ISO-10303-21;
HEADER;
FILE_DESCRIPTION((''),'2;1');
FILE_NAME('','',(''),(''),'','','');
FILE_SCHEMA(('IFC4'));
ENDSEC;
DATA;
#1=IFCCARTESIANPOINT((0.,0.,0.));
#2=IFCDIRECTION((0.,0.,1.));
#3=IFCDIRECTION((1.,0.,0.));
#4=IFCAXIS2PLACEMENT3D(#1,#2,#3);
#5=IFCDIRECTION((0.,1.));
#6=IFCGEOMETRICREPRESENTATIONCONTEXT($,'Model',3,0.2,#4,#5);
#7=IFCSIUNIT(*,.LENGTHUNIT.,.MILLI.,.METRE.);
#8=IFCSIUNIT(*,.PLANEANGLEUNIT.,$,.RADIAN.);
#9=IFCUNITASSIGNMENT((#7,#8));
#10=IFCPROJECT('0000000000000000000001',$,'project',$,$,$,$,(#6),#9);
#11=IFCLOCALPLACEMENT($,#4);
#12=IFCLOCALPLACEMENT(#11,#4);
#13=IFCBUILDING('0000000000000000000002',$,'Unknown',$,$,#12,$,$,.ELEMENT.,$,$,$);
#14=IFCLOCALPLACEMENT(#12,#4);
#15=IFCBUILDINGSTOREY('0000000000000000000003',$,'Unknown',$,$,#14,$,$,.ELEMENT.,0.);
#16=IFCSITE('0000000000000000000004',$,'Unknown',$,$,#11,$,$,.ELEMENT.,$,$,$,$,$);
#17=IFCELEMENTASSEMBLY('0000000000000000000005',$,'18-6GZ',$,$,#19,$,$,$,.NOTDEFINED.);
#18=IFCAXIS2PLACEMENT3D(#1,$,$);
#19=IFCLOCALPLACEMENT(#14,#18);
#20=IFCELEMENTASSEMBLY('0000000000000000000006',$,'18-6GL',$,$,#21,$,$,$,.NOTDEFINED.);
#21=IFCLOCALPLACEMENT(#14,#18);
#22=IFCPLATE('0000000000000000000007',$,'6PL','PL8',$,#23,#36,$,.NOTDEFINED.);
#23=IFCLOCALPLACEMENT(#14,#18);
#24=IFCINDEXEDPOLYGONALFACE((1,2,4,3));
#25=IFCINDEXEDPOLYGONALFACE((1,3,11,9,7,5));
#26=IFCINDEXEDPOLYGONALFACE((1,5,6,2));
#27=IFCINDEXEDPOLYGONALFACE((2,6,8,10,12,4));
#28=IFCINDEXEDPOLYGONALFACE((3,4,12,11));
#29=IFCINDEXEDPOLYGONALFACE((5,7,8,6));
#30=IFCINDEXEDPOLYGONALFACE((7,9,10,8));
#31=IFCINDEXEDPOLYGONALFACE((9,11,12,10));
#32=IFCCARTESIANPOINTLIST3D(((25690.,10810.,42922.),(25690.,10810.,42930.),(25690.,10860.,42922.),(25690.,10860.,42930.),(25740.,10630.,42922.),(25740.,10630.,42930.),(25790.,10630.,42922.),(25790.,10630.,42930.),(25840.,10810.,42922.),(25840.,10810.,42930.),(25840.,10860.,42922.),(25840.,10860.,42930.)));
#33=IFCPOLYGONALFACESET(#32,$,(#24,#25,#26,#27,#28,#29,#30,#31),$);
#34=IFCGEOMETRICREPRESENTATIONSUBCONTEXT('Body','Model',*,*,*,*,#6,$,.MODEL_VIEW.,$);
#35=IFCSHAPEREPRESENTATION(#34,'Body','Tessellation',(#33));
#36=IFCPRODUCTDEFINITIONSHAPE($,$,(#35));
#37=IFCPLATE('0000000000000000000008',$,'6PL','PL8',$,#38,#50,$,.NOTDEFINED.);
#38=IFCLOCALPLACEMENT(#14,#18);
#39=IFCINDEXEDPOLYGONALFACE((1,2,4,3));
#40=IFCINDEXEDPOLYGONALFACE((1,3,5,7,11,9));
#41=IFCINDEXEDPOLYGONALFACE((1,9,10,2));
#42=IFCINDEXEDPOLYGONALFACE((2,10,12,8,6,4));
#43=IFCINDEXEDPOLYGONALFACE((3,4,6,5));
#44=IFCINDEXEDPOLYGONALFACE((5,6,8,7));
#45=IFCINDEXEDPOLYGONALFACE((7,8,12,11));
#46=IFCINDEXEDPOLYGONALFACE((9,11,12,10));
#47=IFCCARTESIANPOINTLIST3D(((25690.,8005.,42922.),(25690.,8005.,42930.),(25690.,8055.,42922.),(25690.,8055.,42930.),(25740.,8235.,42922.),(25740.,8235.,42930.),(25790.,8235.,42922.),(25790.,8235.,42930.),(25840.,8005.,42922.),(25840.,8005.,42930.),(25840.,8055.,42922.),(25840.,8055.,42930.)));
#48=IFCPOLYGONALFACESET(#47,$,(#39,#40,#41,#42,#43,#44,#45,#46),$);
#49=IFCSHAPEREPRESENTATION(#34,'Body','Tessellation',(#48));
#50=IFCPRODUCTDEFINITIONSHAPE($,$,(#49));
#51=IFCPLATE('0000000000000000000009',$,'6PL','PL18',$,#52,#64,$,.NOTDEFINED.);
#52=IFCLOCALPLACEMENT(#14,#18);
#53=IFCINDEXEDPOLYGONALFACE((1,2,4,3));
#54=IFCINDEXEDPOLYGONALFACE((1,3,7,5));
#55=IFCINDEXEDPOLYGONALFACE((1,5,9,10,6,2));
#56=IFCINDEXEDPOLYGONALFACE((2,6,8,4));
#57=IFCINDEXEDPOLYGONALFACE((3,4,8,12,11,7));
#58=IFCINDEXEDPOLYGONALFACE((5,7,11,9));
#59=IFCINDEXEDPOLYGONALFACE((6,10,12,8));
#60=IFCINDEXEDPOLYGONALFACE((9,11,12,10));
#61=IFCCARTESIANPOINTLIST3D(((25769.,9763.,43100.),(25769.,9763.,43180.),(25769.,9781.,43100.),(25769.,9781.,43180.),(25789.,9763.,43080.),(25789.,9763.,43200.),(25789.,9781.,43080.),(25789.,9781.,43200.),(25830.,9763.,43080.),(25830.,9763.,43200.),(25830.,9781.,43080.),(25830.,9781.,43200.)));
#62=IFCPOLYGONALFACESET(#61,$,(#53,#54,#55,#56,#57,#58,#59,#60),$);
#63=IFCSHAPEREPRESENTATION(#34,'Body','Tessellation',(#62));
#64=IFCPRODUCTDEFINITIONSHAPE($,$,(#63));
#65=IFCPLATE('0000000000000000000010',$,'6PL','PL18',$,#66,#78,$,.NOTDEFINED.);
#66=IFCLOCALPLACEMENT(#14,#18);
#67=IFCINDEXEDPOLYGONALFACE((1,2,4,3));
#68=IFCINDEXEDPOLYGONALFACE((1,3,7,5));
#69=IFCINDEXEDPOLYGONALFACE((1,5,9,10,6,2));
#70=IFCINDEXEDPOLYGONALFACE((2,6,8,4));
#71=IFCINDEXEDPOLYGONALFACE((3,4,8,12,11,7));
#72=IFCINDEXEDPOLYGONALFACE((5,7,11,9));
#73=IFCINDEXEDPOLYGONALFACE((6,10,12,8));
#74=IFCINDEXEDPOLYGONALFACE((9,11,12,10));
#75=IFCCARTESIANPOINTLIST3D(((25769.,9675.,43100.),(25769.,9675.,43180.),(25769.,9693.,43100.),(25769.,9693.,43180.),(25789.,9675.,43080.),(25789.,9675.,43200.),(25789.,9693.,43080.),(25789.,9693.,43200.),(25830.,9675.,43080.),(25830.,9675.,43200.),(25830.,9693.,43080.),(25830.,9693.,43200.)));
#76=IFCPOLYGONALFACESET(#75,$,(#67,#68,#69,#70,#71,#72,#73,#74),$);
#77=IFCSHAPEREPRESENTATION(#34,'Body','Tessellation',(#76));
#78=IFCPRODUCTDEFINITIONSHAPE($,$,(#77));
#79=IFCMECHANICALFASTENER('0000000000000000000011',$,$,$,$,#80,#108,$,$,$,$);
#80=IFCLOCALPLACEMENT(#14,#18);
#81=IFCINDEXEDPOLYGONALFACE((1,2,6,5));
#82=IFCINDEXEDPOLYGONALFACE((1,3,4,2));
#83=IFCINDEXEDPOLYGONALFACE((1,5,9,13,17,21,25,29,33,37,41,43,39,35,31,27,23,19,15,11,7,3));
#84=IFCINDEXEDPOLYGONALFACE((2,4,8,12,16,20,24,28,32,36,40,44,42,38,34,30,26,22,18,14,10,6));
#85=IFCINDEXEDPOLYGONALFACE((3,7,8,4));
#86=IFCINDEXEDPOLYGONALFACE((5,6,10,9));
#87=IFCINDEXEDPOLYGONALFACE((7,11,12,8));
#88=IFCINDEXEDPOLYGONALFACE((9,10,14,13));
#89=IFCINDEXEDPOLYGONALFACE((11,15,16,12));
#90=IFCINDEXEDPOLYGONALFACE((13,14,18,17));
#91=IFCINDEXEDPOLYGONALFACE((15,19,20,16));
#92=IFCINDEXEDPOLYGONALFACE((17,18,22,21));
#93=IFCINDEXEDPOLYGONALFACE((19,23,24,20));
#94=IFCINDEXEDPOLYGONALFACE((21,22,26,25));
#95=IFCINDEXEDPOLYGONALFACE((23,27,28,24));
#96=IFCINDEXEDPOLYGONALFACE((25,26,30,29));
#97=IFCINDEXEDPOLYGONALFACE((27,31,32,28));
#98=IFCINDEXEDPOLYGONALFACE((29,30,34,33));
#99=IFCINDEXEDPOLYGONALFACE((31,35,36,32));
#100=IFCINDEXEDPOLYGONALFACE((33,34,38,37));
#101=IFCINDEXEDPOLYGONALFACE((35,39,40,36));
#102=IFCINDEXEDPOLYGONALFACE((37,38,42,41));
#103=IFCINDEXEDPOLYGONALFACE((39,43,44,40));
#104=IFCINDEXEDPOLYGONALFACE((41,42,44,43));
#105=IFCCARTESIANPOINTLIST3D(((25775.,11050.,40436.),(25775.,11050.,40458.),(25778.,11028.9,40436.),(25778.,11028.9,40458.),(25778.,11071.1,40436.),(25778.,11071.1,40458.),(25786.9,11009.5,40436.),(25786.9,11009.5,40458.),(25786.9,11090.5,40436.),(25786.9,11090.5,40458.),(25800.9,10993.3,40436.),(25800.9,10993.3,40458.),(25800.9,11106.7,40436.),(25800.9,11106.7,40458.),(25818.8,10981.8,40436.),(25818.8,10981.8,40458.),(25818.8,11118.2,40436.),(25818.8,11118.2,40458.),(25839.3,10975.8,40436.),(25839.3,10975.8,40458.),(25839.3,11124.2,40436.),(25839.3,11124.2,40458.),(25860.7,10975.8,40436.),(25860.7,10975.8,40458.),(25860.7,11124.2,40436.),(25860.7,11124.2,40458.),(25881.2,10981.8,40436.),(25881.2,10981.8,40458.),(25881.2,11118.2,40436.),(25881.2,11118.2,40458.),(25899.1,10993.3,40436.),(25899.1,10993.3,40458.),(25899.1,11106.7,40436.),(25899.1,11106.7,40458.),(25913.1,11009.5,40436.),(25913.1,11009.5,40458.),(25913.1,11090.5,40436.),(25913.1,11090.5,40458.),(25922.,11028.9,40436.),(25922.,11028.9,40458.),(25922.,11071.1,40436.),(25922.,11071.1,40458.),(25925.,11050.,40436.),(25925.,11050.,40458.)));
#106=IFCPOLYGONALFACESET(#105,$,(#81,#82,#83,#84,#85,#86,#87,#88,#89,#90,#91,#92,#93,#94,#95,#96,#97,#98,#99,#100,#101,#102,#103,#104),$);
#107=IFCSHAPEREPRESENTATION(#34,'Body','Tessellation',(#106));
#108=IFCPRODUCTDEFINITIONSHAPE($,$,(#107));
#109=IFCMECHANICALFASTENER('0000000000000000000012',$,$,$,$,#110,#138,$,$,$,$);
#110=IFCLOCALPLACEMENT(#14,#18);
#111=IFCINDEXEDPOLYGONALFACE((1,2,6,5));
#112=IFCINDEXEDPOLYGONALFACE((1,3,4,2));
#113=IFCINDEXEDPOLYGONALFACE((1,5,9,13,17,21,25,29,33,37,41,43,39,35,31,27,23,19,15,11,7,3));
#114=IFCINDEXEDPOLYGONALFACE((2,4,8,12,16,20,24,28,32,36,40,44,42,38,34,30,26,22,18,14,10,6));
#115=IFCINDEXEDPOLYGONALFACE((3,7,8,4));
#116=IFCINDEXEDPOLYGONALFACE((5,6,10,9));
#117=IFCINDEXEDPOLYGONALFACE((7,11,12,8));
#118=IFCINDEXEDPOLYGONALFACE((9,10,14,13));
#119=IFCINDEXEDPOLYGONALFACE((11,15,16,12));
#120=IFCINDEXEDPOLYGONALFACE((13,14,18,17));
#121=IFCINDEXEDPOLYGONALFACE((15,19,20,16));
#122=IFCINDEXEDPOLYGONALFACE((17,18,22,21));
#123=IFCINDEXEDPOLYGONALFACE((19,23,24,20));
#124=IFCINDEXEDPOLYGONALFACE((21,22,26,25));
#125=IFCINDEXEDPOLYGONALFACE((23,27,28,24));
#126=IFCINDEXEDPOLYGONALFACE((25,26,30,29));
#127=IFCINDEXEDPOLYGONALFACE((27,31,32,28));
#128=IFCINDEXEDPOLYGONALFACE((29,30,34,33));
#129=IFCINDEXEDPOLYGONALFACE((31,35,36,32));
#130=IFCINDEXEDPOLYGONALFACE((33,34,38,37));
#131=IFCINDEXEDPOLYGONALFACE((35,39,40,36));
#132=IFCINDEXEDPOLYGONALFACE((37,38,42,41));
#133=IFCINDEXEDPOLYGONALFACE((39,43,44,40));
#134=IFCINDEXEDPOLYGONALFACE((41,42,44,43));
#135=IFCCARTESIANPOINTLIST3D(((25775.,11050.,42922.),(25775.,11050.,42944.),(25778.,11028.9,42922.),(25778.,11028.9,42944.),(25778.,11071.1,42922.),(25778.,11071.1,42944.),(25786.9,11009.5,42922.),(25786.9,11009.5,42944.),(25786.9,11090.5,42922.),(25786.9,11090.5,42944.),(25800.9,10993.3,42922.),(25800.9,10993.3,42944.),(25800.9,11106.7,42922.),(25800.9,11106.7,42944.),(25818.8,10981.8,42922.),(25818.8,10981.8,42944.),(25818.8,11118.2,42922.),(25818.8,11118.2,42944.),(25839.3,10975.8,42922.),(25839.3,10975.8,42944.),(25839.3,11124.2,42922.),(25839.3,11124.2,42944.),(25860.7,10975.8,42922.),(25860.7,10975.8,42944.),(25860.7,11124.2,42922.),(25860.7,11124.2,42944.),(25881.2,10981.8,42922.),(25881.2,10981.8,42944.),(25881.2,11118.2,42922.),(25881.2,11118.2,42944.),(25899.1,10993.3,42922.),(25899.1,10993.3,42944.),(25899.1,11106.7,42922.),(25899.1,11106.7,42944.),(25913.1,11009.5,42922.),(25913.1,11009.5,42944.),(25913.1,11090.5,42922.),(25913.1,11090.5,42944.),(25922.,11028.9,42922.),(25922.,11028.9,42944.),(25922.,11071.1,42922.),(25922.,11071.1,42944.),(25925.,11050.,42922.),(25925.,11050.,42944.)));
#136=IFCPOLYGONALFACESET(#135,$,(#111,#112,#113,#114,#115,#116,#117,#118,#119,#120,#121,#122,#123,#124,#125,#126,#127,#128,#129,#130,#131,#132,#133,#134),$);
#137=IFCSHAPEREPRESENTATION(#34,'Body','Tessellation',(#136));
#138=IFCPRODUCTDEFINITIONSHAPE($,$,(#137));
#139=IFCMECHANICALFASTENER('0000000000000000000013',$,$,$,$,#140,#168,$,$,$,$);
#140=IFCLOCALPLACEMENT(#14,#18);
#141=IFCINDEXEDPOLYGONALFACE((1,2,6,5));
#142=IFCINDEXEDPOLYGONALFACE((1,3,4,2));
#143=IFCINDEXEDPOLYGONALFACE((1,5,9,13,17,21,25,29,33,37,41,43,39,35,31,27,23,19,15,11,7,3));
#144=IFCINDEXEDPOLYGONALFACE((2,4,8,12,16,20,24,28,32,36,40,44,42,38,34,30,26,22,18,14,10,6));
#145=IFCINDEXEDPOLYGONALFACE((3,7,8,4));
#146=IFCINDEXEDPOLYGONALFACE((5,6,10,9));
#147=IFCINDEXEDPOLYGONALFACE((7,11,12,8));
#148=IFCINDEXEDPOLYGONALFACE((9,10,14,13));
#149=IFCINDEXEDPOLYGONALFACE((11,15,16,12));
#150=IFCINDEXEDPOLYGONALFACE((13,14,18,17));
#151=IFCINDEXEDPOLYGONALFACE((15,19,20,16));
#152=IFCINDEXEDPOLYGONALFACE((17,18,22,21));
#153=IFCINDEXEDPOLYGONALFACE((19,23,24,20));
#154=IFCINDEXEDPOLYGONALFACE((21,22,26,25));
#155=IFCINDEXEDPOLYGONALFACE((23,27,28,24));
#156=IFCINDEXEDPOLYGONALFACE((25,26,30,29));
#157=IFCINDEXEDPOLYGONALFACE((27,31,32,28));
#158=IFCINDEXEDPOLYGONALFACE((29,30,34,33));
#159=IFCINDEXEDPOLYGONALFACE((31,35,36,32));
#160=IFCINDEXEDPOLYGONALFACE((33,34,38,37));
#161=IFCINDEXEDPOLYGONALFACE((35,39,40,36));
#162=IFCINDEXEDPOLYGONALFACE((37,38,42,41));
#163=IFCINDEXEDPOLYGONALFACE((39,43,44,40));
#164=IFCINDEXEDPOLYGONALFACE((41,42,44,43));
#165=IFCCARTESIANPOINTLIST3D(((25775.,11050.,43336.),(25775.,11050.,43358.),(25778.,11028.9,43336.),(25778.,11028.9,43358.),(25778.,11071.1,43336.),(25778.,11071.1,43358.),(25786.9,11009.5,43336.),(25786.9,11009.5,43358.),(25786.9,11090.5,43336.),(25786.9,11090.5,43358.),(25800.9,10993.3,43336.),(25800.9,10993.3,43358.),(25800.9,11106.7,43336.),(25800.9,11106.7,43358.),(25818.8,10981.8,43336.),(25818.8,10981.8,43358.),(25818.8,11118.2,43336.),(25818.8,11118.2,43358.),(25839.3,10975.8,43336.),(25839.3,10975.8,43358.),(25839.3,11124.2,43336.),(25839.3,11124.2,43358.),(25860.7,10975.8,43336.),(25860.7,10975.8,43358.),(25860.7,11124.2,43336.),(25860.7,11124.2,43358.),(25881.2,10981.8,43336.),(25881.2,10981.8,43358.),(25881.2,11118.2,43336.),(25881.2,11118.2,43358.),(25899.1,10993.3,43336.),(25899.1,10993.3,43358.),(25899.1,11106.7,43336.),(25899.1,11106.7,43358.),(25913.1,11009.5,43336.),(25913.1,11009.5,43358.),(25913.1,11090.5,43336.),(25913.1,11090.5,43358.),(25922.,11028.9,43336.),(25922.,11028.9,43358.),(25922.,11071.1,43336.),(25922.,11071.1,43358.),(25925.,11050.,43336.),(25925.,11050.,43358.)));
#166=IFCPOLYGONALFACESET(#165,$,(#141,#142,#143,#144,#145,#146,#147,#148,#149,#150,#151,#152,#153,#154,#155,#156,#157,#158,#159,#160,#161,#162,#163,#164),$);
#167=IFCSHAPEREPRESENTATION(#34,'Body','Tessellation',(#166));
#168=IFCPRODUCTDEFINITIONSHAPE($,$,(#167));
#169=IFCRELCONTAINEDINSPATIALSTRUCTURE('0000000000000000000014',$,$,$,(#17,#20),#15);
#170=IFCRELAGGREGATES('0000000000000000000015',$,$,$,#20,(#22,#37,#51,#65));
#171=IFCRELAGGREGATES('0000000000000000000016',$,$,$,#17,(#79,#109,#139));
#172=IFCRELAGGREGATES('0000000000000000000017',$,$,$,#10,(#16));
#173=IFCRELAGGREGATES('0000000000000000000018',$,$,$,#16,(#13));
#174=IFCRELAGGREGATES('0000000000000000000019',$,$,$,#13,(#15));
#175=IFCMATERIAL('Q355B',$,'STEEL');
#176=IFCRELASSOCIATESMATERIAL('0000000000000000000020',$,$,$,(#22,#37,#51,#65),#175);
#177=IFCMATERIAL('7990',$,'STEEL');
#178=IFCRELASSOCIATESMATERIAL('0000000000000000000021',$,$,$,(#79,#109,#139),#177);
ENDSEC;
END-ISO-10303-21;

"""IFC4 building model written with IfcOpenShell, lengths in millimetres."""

from ifc_helpers import new_model, si_unit, direction, frame, origin_with_axes, place, context, subcontext, project, spatial, line, arc, indexed_curve, outline, extrude, source, transform, mapped, material, element, aggregate, save


model = new_model("IFC4")

# Units and contexts
model_context = context("Model", 3, precision=0.2, world=origin_with_axes(), true_north=direction((0.0, 1.0)))
body_context = subcontext(model_context, "Body", "Model", "MODEL_VIEW")
ifc_project = project(units=[si_unit("LENGTHUNIT", "METRE", prefix="MILLI"), si_unit("PLANEANGLEUNIT", "RADIAN")], contexts=[model_context])

# Site, building, storey
site_placement = place(None, origin_with_axes())
site = spatial("IfcSite", under=ifc_project, at=site_placement, Name="Unknown", CompositionType="ELEMENT")
building_placement = place(site_placement, origin_with_axes())
building = spatial("IfcBuilding", under=site, at=building_placement, Name="Unknown", CompositionType="ELEMENT")
storey_placement = place(building_placement, origin_with_axes())
storey = spatial("IfcBuildingStorey", under=building, at=storey_placement, Name="Unknown", CompositionType="ELEMENT", Elevation=0.0)

# Element assembly
assembly_1_placement = place(storey_placement, frame((25850.0, 11050.0, 35950.0), z_axis=(-1.0, 0.0, 0.0), x_axis=(0.0, 0.0, 1.0)))
assembly_1 = element("IfcElementAssembly", 1, at=assembly_1_placement, inside=storey, Name="18-6GZ", PredefinedType="NOTDEFINED")
ifc_material_1 = material(Name="Q355B", Category="STEEL")

# Element assembly
assembly_2_placement = place(storey_placement, frame((25765.0, 10900.0, 43140.0), z_axis=(-1.0, 0.0, 0.0), x_axis=(0.0, -1.0, 0.0)))
assembly_2 = element("IfcElementAssembly", 2, at=assembly_2_placement, inside=storey, Name="18-6GL", PredefinedType="NOTDEFINED")

# Plates
plate_1_placement = place(assembly_2_placement, frame((90.0, -214.0, -75.0), z_axis=(0.0, 1.0, 0.0), x_axis=(-1.0, 0.0, 0.0)))
plate_1 = element("IfcPlate", 3, at=plate_1_placement, material=ifc_material_1, Name="6PL", Description="PL8", PredefinedType="NOTDEFINED", context=body_context, shape_type="SolidModel", body=[
    extrude(outline(indexed_curve([(0.0, 0.0), (50.0, 0.0), (50.0, 150.0), (0.0, 150.0), (-180.0, 100.0), (-180.0, 50.0)], segments=[line(1, 2, 3, 4, 5, 6, 1)])), frame((0.0, 0.0, 4.0), z_axis=(0.0, 0.0, 1.0), x_axis=(1.0, 0.0, 0.0)), (0.0, 0.0, -1.0), 8.0),
])
plate_2_placement = place(assembly_2_placement, frame((2845.0, -214.0, -75.0), z_axis=(0.0, -1.0, 0.0), x_axis=(1.0, 0.0, 0.0)))
plate_2 = element("IfcPlate", 4, at=plate_2_placement, material=ifc_material_1, Name="6PL", Description="PL8", PredefinedType="NOTDEFINED", context=body_context, shape_type="SolidModel", body=[
    extrude(outline(indexed_curve([(0.0, 0.0), (50.0, 0.0), (50.0, 150.0), (0.0, 150.0), (-180.0, 100.0), (-180.0, 50.0)], segments=[line(1, 2, 3, 4, 5, 6, 1)])), frame((0.0, 0.0, 4.0), z_axis=(0.0, 0.0, 1.0), x_axis=(1.0, 0.0, 0.0)), (0.0, 0.0, -1.0), 8.0),
])
plate_3_placement = place(assembly_2_placement, frame((1128.0, -60.0, -65.0), z_axis=(-1.0, 0.0, 0.0), x_axis=(0.0, 0.0, 1.0)))
plate_3 = element("IfcPlate", 5, at=plate_3_placement, material=ifc_material_1, Name="6PL", Description="PL18", PredefinedType="NOTDEFINED", context=body_context, shape_type="SolidModel", body=[
    extrude(outline(indexed_curve([(0.0, 0.0), (41.0, 0.0), (61.0, 20.0), (61.0, 100.0), (41.0, 120.0), (0.0, 120.0)], segments=[line(1, 2, 3, 4, 5, 6, 1)])), frame((0.0, 0.0, 9.0), z_axis=(0.0, 0.0, 1.0), x_axis=(1.0, 0.0, 0.0)), (0.0, 0.0, -1.0), 18.0),
])
plate_4_placement = place(assembly_2_placement, frame((1216.0, -60.0, -65.0), z_axis=(-1.0, 0.0, 0.0), x_axis=(0.0, 0.0, 1.0)))
plate_4 = element("IfcPlate", 6, at=plate_4_placement, material=ifc_material_1, Name="6PL", Description="PL18", PredefinedType="NOTDEFINED", context=body_context, shape_type="SolidModel", body=[
    extrude(outline(indexed_curve([(0.0, 0.0), (41.0, 0.0), (61.0, 20.0), (61.0, 100.0), (41.0, 120.0), (0.0, 120.0)], segments=[line(1, 2, 3, 4, 5, 6, 1)])), frame((0.0, 0.0, 9.0), z_axis=(0.0, 0.0, 1.0), x_axis=(1.0, 0.0, 0.0)), (0.0, 0.0, -1.0), 18.0),
])
aggregate(assembly_2, [plate_1, plate_2, plate_3, plate_4])

# Mechanical fasteners
ifc_material_2 = material(Name="7990", Category="STEEL")
shared_shape_1 = source(origin_with_axes(), body_context, "Body", "SweptSolid", [
    extrude(outline(indexed_curve([(75.0, 0.0), (0.0, 75.0), (-75.0, 0.0), (0.0, -75.0)], segments=[arc(1, 2, 3), arc(3, 4, 1)])), frame((0.0, 0.0, 0.0), z_axis=(0.0, 0.0, -1.0), x_axis=(0.0, 1.0, 0.0)), (0.0, 0.0, 1.0), 22.0),
])
placement_1 = place(assembly_1_placement, frame((4508.0, 0.0, 0.0), z_axis=(1.0, 0.0, 0.0), x_axis=(0.0, 1.0, 0.0)))
mechanical_fastener_1 = element("IfcMechanicalFastener", 7, at=placement_1, material=ifc_material_2, context=body_context, shape_type="MappedRepresentation", body=[
    mapped(shared_shape_1, transform((0.0, 0.0, 0.0))),
])
placement_2 = place(assembly_1_placement, frame((6972.0, 0.0, 0.0), z_axis=(-1.0, 0.0, 0.0), x_axis=(0.0, 1.0, 0.0)))
mechanical_fastener_2 = element("IfcMechanicalFastener", 8, at=placement_2, material=ifc_material_2, context=body_context, shape_type="MappedRepresentation", body=[
    mapped(shared_shape_1, transform((0.0, 0.0, 0.0))),
])
placement_3 = place(assembly_1_placement, frame((7408.0, 0.0, 0.0), z_axis=(1.0, 0.0, 0.0), x_axis=(0.0, 1.0, 0.0)))
mechanical_fastener_3 = element("IfcMechanicalFastener", 9, at=placement_3, material=ifc_material_2, context=body_context, shape_type="MappedRepresentation", body=[
    mapped(shared_shape_1, transform((0.0, 0.0, 0.0))),
])
aggregate(assembly_1, [mechanical_fastener_1, mechanical_fastener_2, mechanical_fastener_3])

save(model, "model.ifc")
